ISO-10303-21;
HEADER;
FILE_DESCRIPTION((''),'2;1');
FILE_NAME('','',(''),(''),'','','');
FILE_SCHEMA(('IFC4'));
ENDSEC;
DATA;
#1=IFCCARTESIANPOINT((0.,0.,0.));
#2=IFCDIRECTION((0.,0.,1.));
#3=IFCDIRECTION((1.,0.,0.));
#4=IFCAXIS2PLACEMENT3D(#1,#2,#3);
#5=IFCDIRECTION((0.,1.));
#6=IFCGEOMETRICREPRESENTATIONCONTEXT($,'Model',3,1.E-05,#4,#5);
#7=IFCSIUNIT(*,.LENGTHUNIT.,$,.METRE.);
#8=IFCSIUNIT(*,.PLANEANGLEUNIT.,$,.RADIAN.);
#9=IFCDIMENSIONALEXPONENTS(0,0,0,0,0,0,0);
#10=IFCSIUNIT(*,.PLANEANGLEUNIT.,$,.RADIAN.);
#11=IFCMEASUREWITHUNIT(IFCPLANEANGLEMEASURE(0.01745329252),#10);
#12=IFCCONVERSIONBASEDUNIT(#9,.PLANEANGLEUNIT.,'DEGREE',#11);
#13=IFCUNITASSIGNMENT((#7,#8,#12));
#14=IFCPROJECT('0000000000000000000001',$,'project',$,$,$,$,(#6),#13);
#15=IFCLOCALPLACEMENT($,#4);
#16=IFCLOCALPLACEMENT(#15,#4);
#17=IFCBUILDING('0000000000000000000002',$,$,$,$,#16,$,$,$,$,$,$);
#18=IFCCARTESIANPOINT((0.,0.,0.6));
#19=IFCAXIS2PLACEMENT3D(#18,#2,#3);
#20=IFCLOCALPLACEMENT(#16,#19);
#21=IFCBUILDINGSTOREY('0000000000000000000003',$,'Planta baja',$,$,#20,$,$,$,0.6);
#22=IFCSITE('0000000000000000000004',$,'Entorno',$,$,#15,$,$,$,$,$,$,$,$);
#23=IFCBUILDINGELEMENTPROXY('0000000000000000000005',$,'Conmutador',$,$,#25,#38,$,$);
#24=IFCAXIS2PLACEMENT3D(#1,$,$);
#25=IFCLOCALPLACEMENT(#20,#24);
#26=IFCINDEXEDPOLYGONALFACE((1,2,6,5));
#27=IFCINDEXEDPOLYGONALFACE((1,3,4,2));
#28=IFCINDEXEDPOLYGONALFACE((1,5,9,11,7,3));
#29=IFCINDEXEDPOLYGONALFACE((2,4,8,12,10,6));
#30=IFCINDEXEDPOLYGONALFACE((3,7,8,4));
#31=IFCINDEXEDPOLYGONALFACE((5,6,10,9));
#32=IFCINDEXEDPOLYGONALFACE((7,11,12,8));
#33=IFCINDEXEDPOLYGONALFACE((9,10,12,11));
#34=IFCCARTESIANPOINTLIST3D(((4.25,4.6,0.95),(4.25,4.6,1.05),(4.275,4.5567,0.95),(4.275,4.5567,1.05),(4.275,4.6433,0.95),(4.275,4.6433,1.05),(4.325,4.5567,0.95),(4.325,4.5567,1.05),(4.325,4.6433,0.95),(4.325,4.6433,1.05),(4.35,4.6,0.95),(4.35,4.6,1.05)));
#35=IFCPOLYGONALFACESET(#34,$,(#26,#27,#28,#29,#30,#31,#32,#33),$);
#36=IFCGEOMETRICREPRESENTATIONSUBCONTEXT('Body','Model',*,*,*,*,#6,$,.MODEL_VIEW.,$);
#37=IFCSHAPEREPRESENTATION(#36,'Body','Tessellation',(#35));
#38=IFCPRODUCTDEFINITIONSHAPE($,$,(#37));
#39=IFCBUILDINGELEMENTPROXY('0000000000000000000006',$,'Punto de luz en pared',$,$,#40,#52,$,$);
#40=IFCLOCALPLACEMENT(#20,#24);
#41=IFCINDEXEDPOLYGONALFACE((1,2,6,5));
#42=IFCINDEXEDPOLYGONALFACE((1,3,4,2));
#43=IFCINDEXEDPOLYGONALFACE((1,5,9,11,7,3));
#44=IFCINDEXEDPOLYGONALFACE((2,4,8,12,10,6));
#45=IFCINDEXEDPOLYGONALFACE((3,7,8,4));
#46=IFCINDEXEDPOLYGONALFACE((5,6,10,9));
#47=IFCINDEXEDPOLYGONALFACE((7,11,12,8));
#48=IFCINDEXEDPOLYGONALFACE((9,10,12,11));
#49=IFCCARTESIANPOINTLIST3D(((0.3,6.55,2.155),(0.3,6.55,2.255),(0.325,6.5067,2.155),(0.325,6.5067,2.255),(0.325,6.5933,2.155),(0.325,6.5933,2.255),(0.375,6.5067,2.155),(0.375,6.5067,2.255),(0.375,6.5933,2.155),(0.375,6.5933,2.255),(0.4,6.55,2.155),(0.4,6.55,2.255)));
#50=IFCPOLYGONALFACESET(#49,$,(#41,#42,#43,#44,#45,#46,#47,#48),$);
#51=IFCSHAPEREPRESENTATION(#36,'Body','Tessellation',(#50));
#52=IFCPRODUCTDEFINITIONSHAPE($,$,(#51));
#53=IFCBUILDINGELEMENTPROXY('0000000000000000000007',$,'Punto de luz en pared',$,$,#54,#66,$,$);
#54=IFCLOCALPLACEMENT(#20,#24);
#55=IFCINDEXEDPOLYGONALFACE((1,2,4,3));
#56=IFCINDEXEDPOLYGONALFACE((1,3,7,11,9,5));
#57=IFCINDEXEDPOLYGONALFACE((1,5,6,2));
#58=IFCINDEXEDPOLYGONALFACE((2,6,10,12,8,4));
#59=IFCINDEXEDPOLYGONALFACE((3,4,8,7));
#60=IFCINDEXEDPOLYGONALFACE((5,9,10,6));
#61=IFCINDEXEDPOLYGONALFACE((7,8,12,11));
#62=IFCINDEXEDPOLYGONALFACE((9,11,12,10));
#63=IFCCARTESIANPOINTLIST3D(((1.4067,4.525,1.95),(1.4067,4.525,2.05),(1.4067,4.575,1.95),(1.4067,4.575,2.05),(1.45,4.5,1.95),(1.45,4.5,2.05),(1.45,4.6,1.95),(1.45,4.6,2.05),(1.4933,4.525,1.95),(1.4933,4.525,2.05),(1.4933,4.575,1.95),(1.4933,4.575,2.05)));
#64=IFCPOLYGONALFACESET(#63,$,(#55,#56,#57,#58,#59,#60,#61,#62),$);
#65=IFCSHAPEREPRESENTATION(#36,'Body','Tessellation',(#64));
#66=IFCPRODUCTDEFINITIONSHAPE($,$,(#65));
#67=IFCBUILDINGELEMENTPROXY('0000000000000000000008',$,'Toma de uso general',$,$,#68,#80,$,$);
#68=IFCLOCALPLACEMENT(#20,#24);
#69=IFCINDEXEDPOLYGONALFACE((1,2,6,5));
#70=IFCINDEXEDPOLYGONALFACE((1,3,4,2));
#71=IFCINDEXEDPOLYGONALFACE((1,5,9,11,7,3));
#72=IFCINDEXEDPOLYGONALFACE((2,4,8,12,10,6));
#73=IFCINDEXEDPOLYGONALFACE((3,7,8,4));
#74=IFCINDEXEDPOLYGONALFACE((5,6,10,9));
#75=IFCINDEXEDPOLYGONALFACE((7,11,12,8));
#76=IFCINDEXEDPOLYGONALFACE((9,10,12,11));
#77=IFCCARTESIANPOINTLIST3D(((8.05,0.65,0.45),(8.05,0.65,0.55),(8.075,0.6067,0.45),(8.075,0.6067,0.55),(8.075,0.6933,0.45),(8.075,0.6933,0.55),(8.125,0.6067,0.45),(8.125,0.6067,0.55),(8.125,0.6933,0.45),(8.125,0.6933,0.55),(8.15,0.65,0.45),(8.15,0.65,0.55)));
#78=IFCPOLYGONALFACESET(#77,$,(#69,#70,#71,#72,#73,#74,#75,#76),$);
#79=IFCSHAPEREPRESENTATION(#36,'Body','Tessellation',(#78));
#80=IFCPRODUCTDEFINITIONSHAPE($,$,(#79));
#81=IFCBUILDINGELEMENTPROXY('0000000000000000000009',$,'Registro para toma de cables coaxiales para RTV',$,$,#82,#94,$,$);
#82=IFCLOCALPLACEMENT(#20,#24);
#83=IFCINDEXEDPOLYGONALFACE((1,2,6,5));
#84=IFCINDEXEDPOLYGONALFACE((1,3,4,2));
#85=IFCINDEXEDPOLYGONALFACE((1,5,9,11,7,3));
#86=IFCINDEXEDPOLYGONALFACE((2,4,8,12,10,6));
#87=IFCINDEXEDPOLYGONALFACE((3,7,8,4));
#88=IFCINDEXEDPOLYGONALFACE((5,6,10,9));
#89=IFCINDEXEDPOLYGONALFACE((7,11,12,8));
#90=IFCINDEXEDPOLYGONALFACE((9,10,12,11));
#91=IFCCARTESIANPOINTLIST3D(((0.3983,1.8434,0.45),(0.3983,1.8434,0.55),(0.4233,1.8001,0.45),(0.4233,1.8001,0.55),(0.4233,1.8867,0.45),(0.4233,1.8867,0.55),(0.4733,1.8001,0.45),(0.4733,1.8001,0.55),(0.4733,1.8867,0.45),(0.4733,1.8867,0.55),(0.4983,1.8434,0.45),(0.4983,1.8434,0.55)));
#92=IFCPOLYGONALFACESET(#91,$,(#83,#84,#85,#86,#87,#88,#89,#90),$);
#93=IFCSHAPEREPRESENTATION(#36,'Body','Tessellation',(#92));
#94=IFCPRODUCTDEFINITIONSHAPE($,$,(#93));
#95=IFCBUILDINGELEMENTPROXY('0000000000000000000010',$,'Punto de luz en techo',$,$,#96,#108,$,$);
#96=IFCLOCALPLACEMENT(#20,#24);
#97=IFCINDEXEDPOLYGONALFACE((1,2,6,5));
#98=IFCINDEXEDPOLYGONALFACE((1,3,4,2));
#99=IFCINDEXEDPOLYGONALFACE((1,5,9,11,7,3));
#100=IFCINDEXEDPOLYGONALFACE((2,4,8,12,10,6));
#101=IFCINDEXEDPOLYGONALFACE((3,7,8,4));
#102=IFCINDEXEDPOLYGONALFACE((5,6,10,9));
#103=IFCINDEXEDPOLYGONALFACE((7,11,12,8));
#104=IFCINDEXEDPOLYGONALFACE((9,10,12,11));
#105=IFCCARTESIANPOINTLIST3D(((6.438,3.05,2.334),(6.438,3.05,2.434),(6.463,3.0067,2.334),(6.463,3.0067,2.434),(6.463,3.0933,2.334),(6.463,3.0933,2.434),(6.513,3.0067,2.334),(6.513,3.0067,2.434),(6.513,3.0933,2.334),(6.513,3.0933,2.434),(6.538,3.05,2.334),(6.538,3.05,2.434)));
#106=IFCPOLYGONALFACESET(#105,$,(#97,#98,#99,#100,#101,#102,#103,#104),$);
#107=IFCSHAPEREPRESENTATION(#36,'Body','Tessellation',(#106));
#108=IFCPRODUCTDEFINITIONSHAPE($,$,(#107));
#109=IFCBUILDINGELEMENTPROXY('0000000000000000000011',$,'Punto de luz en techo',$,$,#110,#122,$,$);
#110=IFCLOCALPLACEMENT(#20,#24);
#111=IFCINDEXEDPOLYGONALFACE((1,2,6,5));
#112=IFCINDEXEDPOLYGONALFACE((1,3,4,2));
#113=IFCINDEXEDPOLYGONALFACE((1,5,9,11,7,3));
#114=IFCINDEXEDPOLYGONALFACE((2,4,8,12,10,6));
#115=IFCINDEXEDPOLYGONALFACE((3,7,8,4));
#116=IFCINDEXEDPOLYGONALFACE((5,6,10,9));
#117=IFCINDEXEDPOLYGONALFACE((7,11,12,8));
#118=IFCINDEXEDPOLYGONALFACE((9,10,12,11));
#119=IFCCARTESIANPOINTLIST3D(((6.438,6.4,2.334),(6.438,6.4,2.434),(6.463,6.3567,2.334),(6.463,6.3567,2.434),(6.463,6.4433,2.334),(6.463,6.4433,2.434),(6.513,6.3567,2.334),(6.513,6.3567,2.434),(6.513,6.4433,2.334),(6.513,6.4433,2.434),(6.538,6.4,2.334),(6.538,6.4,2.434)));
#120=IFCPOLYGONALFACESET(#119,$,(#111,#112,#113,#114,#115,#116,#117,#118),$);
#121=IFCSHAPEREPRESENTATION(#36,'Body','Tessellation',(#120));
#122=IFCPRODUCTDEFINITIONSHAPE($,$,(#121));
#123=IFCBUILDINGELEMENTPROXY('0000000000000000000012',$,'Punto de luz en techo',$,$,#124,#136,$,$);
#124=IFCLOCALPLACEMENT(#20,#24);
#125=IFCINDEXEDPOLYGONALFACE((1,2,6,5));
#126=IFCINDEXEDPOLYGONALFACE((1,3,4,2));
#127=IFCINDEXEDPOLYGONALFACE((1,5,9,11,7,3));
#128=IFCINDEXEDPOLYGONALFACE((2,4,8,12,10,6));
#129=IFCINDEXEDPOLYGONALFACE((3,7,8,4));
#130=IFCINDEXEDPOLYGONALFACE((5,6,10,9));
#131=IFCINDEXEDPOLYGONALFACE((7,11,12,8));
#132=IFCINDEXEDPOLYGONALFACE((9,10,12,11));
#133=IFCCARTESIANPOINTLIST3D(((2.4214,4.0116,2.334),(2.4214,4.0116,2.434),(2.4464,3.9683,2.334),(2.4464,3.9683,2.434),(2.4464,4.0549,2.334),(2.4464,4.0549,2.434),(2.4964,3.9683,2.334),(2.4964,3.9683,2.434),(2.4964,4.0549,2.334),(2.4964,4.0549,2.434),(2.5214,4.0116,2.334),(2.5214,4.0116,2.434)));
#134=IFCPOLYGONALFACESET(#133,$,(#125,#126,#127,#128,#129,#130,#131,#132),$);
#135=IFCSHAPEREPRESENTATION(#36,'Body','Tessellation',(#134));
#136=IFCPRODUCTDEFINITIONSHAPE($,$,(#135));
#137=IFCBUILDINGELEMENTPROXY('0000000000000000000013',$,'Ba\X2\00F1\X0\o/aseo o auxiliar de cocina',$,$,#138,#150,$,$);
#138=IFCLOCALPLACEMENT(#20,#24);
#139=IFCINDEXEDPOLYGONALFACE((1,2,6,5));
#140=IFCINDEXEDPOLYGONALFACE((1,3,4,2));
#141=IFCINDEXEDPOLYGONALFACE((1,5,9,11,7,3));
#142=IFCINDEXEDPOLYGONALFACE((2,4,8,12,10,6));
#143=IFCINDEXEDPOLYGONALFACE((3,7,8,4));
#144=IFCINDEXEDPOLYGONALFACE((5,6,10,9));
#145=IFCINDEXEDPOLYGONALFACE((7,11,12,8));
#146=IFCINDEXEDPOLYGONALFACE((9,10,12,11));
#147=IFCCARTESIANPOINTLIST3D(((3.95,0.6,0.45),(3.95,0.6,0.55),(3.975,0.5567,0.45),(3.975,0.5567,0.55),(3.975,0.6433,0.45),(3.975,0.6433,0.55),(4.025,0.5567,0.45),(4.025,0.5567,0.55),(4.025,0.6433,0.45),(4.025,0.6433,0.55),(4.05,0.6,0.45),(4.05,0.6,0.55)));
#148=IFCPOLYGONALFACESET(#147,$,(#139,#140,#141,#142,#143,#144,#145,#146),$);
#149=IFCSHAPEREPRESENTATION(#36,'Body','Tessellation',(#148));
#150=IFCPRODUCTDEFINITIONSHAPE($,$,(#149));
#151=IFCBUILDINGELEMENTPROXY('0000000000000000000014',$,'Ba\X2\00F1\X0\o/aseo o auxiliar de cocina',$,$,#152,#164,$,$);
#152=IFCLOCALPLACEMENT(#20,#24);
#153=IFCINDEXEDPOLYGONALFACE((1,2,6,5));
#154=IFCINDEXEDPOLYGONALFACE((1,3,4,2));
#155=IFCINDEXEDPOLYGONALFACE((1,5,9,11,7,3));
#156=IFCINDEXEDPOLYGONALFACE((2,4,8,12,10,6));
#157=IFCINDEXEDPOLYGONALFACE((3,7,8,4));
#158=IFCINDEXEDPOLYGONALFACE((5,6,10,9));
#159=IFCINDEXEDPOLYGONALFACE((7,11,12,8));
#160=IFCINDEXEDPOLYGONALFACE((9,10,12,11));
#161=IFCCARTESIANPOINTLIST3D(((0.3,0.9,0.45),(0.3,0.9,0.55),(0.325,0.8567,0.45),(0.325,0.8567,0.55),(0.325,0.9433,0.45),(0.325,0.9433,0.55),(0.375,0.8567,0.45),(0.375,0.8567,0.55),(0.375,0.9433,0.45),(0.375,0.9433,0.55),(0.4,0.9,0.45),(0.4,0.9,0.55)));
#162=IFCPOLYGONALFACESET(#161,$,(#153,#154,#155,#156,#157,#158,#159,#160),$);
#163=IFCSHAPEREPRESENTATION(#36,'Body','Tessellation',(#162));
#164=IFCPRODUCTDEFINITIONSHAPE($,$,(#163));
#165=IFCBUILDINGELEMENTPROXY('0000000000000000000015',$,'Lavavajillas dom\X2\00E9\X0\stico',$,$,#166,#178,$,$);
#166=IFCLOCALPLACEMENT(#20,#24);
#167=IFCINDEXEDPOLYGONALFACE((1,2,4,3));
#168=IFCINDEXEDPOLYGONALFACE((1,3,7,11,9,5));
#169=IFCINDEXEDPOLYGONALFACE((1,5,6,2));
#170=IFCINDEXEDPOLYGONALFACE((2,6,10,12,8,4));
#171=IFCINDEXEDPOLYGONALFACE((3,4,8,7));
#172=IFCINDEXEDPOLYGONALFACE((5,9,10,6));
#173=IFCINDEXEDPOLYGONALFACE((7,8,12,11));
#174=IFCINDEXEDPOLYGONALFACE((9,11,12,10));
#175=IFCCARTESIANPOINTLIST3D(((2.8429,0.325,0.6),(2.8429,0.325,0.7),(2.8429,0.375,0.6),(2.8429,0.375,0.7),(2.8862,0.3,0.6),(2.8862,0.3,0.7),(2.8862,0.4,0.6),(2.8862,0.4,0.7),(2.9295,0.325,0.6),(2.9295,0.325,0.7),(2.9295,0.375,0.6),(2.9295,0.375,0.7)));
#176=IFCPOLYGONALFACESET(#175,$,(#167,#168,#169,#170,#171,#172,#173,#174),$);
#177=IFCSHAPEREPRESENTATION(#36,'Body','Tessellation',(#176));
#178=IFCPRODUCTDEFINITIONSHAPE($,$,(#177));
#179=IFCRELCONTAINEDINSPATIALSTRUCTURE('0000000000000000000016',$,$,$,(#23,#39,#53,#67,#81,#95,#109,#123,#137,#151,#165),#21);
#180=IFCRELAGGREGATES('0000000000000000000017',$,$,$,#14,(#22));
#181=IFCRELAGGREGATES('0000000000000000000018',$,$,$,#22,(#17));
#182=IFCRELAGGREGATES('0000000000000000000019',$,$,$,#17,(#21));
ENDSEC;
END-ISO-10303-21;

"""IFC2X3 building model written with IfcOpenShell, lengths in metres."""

from ifc_helpers import new_model, entity, si_unit, converted_unit, direction, frame, origin_with_axes, place, context, subcontext, project, spatial, polyline, outline, extrude, source, transform, mapped, element, save


model = new_model("IFC2X3")

# Units and contexts
model_context = context("Model", 3, precision=1e-05, world=origin_with_axes(), true_north=direction((0.0, 1.0)))
body_context = subcontext(model_context, "Body", "Model", "MODEL_VIEW")
ifc_project = project(units=[si_unit("LENGTHUNIT", "METRE"), si_unit("PLANEANGLEUNIT", "RADIAN"), converted_unit("PLANEANGLEUNIT", "DEGREE", entity("IfcPlaneAngleMeasure", 0.01745329252), si_unit("PLANEANGLEUNIT", "RADIAN"), dimensions=[0, 0, 0, 0, 0, 0, 0])], contexts=[model_context])

# Site, building, storey
site_placement = place(None, origin_with_axes())
site = spatial("IfcSite", under=ifc_project, at=site_placement, Name="Entorno")
building_placement = place(site_placement, origin_with_axes())
building = spatial("IfcBuilding", under=site, at=building_placement)
storey_placement = place(building_placement, frame((0.0, 0.0, 0.6), z_axis=(0.0, 0.0, 1.0), x_axis=(1.0, 0.0, 0.0)))
storey = spatial("IfcBuildingStorey", under=building, at=storey_placement, Name="Planta baja", Elevation=0.6)

# Building element proxies
shared_shape_1 = source(origin_with_axes(), body_context, "Body", "SolidModel", [
    extrude(outline(polyline([(0.05, 0.0), (0.025, 0.0433), (-0.025, 0.0433), (-0.05, 0.0), (-0.025, -0.0433), (0.025, -0.0433), (0.05, 0.0)])), frame((0.0, 0.0, -0.05), z_axis=(0.0, 0.0, 1.0), x_axis=(1.0, 0.0, 0.0)), (0.0, 0.0, 1.0), 0.1),
])
proxy_1_placement = place(storey_placement, frame((0.0, 0.0, -0.6), z_axis=(0.0, 0.0, 1.0), x_axis=(1.0, 0.0, 0.0)))
element("IfcBuildingElementProxy", 1, at=proxy_1_placement, inside=storey, Name="Conmutador", context=body_context, shape_type="Brep", body=[
    mapped(shared_shape_1, transform((4.3, 4.6, 1.6), x_axis=(1.0, 0.0, 0.0), y_axis=(0.0, 1.0, 0.0), z_axis=(0.0, 0.0, 1.0))),
])
shared_shape_2 = source(origin_with_axes(), body_context, "Body", "SolidModel", [
    extrude(outline(polyline([(0.05, 0.0), (0.025, 0.0433), (-0.025, 0.0433), (-0.05, 0.0), (-0.025, -0.0433), (0.025, -0.0433), (0.05, 0.0)])), frame((0.0, 0.0, -0.05), z_axis=(0.0, 0.0, 1.0), x_axis=(1.0, 0.0, 0.0)), (0.0, 0.0, 1.0), 0.1),
])
proxy_2_placement = place(storey_placement, frame((0.0, 0.0, -0.6), z_axis=(0.0, 0.0, 1.0), x_axis=(1.0, 0.0, 0.0)))
element("IfcBuildingElementProxy", 2, at=proxy_2_placement, inside=storey, Name="Punto de luz en pared", context=body_context, shape_type="Brep", body=[
    mapped(shared_shape_2, transform((0.35, 6.55, 2.805), x_axis=(1.0, 0.0, 0.0), y_axis=(0.0, 1.0, 0.0), z_axis=(0.0, 0.0, 1.0))),
])
proxy_3_placement = place(storey_placement, frame((0.0, 0.0, -0.6), z_axis=(0.0, 0.0, 1.0), x_axis=(1.0, 0.0, 0.0)))
element("IfcBuildingElementProxy", 3, at=proxy_3_placement, inside=storey, Name="Punto de luz en pared", context=body_context, shape_type="Brep", body=[
    mapped(shared_shape_2, transform((1.45, 4.55, 2.6), x_axis=(0.0, -1.0, 0.0), y_axis=(1.0, 0.0, 0.0), z_axis=(0.0, 0.0, 1.0))),
])
shared_shape_3 = source(origin_with_axes(), body_context, "Body", "SolidModel", [
    extrude(outline(polyline([(0.05, 0.0), (0.025, 0.0433), (-0.025, 0.0433), (-0.05, 0.0), (-0.025, -0.0433), (0.025, -0.0433), (0.05, 0.0)])), frame((0.0, 0.0, -0.05), z_axis=(0.0, 0.0, 1.0), x_axis=(1.0, 0.0, 0.0)), (0.0, 0.0, 1.0), 0.1),
])
proxy_4_placement = place(storey_placement, frame((0.0, 0.0, -0.6), z_axis=(0.0, 0.0, 1.0), x_axis=(1.0, 0.0, 0.0)))
element("IfcBuildingElementProxy", 4, at=proxy_4_placement, inside=storey, Name="Toma de uso general", context=body_context, shape_type="Brep", body=[
    mapped(shared_shape_3, transform((8.1, 0.65, 1.1), x_axis=(-1.0, 0.0, 0.0), y_axis=(0.0, -1.0, 0.0), z_axis=(0.0, 0.0, 1.0))),
])
shared_shape_4 = source(origin_with_axes(), body_context, "Body", "SolidModel", [
    extrude(outline(polyline([(0.05, 0.0), (0.025, 0.0433), (-0.025, 0.0433), (-0.05, 0.0), (-0.025, -0.0433), (0.025, -0.0433), (0.05, 0.0)])), frame((0.0, 0.0, -0.05), z_axis=(0.0, 0.0, 1.0), x_axis=(1.0, 0.0, 0.0)), (0.0, 0.0, 1.0), 0.1),
])
proxy_5_placement = place(storey_placement, frame((0.0, 0.0, -0.6), z_axis=(0.0, 0.0, 1.0), x_axis=(1.0, 0.0, 0.0)))
element("IfcBuildingElementProxy", 5, at=proxy_5_placement, inside=storey, Name="Registro para toma de cables coaxiales para RTV", context=body_context, shape_type="Brep", body=[
    mapped(shared_shape_4, transform((0.4483, 1.8434, 1.1), x_axis=(1.0, 0.0, 0.0), y_axis=(0.0, 1.0, 0.0), z_axis=(0.0, 0.0, 1.0))),
])
shared_shape_5 = source(origin_with_axes(), body_context, "Body", "SolidModel", [
    extrude(outline(polyline([(0.05, 0.0), (0.025, 0.0433), (-0.025, 0.0433), (-0.05, 0.0), (-0.025, -0.0433), (0.025, -0.0433), (0.05, 0.0)])), frame((0.0, 0.0, -0.05), z_axis=(0.0, 0.0, 1.0), x_axis=(1.0, 0.0, 0.0)), (0.0, 0.0, 1.0), 0.1),
])
proxy_6_placement = place(storey_placement, frame((0.0, 0.0, -0.6), z_axis=(0.0, 0.0, 1.0), x_axis=(1.0, 0.0, 0.0)))
element("IfcBuildingElementProxy", 6, at=proxy_6_placement, inside=storey, Name="Punto de luz en techo", context=body_context, shape_type="Brep", body=[
    mapped(shared_shape_5, transform((6.488, 3.05, 2.984), x_axis=(1.0, 0.0, 0.0), y_axis=(0.0, 1.0, 0.0), z_axis=(0.0, 0.0, 1.0))),
])
proxy_7_placement = place(storey_placement, frame((0.0, 0.0, -0.6), z_axis=(0.0, 0.0, 1.0), x_axis=(1.0, 0.0, 0.0)))
element("IfcBuildingElementProxy", 7, at=proxy_7_placement, inside=storey, Name="Punto de luz en techo", context=body_context, shape_type="Brep", body=[
    mapped(shared_shape_5, transform((6.488, 6.4, 2.984), x_axis=(1.0, 0.0, 0.0), y_axis=(0.0, 1.0, 0.0), z_axis=(0.0, 0.0, 1.0))),
])
proxy_8_placement = place(storey_placement, frame((0.0, 0.0, -0.6), z_axis=(0.0, 0.0, 1.0), x_axis=(1.0, 0.0, 0.0)))
element("IfcBuildingElementProxy", 8, at=proxy_8_placement, inside=storey, Name="Punto de luz en techo", context=body_context, shape_type="Brep", body=[
    mapped(shared_shape_5, transform((2.4714, 4.0116, 2.984), x_axis=(1.0, 0.0, 0.0), y_axis=(0.0, 1.0, 0.0), z_axis=(0.0, 0.0, 1.0))),
])
shared_shape_6 = source(origin_with_axes(), body_context, "Body", "SolidModel", [
    extrude(outline(polyline([(0.05, 0.0), (0.025, 0.0433), (-0.025, 0.0433), (-0.05, 0.0), (-0.025, -0.0433), (0.025, -0.0433), (0.05, 0.0)])), frame((0.0, 0.0, -0.05), z_axis=(0.0, 0.0, 1.0), x_axis=(1.0, 0.0, 0.0)), (0.0, 0.0, 1.0), 0.1),
])
proxy_9_placement = place(storey_placement, frame((0.0, 0.0, -0.6), z_axis=(0.0, 0.0, 1.0), x_axis=(1.0, 0.0, 0.0)))
element("IfcBuildingElementProxy", 9, at=proxy_9_placement, inside=storey, Name="Baño/aseo o auxiliar de cocina", context=body_context, shape_type="Brep", body=[
    mapped(shared_shape_6, transform((4.0, 0.6, 1.1), x_axis=(-1.0, 0.0, 0.0), y_axis=(0.0, -1.0, 0.0), z_axis=(0.0, 0.0, 1.0))),
])
proxy_10_placement = place(storey_placement, frame((0.0, 0.0, -0.6), z_axis=(0.0, 0.0, 1.0), x_axis=(1.0, 0.0, 0.0)))
element("IfcBuildingElementProxy", 10, at=proxy_10_placement, inside=storey, Name="Baño/aseo o auxiliar de cocina", context=body_context, shape_type="Brep", body=[
    mapped(shared_shape_6, transform((0.35, 0.9, 1.1), x_axis=(1.0, 0.0, 0.0), y_axis=(0.0, 1.0, 0.0), z_axis=(0.0, 0.0, 1.0))),
])
shared_shape_7 = source(origin_with_axes(), body_context, "Body", "SolidModel", [
    extrude(outline(polyline([(0.05, 0.0), (0.025, 0.0433), (-0.025, 0.0433), (-0.05, 0.0), (-0.025, -0.0433), (0.025, -0.0433), (0.05, 0.0)])), frame((0.0, 0.0, -0.05), z_axis=(0.0, 0.0, 1.0), x_axis=(1.0, 0.0, 0.0)), (0.0, 0.0, 1.0), 0.1),
])
proxy_11_placement = place(storey_placement, frame((0.0, 0.0, -0.6), z_axis=(0.0, 0.0, 1.0), x_axis=(1.0, 0.0, 0.0)))
element("IfcBuildingElementProxy", 11, at=proxy_11_placement, inside=storey, Name="Lavavajillas doméstico", context=body_context, shape_type="Brep", body=[
    mapped(shared_shape_7, transform((2.8862, 0.35, 1.25), x_axis=(0.0, 1.0, 0.0), y_axis=(-1.0, 0.0, 0.0), z_axis=(0.0, 0.0, 1.0))),
])

save(model, "model.ifc")
